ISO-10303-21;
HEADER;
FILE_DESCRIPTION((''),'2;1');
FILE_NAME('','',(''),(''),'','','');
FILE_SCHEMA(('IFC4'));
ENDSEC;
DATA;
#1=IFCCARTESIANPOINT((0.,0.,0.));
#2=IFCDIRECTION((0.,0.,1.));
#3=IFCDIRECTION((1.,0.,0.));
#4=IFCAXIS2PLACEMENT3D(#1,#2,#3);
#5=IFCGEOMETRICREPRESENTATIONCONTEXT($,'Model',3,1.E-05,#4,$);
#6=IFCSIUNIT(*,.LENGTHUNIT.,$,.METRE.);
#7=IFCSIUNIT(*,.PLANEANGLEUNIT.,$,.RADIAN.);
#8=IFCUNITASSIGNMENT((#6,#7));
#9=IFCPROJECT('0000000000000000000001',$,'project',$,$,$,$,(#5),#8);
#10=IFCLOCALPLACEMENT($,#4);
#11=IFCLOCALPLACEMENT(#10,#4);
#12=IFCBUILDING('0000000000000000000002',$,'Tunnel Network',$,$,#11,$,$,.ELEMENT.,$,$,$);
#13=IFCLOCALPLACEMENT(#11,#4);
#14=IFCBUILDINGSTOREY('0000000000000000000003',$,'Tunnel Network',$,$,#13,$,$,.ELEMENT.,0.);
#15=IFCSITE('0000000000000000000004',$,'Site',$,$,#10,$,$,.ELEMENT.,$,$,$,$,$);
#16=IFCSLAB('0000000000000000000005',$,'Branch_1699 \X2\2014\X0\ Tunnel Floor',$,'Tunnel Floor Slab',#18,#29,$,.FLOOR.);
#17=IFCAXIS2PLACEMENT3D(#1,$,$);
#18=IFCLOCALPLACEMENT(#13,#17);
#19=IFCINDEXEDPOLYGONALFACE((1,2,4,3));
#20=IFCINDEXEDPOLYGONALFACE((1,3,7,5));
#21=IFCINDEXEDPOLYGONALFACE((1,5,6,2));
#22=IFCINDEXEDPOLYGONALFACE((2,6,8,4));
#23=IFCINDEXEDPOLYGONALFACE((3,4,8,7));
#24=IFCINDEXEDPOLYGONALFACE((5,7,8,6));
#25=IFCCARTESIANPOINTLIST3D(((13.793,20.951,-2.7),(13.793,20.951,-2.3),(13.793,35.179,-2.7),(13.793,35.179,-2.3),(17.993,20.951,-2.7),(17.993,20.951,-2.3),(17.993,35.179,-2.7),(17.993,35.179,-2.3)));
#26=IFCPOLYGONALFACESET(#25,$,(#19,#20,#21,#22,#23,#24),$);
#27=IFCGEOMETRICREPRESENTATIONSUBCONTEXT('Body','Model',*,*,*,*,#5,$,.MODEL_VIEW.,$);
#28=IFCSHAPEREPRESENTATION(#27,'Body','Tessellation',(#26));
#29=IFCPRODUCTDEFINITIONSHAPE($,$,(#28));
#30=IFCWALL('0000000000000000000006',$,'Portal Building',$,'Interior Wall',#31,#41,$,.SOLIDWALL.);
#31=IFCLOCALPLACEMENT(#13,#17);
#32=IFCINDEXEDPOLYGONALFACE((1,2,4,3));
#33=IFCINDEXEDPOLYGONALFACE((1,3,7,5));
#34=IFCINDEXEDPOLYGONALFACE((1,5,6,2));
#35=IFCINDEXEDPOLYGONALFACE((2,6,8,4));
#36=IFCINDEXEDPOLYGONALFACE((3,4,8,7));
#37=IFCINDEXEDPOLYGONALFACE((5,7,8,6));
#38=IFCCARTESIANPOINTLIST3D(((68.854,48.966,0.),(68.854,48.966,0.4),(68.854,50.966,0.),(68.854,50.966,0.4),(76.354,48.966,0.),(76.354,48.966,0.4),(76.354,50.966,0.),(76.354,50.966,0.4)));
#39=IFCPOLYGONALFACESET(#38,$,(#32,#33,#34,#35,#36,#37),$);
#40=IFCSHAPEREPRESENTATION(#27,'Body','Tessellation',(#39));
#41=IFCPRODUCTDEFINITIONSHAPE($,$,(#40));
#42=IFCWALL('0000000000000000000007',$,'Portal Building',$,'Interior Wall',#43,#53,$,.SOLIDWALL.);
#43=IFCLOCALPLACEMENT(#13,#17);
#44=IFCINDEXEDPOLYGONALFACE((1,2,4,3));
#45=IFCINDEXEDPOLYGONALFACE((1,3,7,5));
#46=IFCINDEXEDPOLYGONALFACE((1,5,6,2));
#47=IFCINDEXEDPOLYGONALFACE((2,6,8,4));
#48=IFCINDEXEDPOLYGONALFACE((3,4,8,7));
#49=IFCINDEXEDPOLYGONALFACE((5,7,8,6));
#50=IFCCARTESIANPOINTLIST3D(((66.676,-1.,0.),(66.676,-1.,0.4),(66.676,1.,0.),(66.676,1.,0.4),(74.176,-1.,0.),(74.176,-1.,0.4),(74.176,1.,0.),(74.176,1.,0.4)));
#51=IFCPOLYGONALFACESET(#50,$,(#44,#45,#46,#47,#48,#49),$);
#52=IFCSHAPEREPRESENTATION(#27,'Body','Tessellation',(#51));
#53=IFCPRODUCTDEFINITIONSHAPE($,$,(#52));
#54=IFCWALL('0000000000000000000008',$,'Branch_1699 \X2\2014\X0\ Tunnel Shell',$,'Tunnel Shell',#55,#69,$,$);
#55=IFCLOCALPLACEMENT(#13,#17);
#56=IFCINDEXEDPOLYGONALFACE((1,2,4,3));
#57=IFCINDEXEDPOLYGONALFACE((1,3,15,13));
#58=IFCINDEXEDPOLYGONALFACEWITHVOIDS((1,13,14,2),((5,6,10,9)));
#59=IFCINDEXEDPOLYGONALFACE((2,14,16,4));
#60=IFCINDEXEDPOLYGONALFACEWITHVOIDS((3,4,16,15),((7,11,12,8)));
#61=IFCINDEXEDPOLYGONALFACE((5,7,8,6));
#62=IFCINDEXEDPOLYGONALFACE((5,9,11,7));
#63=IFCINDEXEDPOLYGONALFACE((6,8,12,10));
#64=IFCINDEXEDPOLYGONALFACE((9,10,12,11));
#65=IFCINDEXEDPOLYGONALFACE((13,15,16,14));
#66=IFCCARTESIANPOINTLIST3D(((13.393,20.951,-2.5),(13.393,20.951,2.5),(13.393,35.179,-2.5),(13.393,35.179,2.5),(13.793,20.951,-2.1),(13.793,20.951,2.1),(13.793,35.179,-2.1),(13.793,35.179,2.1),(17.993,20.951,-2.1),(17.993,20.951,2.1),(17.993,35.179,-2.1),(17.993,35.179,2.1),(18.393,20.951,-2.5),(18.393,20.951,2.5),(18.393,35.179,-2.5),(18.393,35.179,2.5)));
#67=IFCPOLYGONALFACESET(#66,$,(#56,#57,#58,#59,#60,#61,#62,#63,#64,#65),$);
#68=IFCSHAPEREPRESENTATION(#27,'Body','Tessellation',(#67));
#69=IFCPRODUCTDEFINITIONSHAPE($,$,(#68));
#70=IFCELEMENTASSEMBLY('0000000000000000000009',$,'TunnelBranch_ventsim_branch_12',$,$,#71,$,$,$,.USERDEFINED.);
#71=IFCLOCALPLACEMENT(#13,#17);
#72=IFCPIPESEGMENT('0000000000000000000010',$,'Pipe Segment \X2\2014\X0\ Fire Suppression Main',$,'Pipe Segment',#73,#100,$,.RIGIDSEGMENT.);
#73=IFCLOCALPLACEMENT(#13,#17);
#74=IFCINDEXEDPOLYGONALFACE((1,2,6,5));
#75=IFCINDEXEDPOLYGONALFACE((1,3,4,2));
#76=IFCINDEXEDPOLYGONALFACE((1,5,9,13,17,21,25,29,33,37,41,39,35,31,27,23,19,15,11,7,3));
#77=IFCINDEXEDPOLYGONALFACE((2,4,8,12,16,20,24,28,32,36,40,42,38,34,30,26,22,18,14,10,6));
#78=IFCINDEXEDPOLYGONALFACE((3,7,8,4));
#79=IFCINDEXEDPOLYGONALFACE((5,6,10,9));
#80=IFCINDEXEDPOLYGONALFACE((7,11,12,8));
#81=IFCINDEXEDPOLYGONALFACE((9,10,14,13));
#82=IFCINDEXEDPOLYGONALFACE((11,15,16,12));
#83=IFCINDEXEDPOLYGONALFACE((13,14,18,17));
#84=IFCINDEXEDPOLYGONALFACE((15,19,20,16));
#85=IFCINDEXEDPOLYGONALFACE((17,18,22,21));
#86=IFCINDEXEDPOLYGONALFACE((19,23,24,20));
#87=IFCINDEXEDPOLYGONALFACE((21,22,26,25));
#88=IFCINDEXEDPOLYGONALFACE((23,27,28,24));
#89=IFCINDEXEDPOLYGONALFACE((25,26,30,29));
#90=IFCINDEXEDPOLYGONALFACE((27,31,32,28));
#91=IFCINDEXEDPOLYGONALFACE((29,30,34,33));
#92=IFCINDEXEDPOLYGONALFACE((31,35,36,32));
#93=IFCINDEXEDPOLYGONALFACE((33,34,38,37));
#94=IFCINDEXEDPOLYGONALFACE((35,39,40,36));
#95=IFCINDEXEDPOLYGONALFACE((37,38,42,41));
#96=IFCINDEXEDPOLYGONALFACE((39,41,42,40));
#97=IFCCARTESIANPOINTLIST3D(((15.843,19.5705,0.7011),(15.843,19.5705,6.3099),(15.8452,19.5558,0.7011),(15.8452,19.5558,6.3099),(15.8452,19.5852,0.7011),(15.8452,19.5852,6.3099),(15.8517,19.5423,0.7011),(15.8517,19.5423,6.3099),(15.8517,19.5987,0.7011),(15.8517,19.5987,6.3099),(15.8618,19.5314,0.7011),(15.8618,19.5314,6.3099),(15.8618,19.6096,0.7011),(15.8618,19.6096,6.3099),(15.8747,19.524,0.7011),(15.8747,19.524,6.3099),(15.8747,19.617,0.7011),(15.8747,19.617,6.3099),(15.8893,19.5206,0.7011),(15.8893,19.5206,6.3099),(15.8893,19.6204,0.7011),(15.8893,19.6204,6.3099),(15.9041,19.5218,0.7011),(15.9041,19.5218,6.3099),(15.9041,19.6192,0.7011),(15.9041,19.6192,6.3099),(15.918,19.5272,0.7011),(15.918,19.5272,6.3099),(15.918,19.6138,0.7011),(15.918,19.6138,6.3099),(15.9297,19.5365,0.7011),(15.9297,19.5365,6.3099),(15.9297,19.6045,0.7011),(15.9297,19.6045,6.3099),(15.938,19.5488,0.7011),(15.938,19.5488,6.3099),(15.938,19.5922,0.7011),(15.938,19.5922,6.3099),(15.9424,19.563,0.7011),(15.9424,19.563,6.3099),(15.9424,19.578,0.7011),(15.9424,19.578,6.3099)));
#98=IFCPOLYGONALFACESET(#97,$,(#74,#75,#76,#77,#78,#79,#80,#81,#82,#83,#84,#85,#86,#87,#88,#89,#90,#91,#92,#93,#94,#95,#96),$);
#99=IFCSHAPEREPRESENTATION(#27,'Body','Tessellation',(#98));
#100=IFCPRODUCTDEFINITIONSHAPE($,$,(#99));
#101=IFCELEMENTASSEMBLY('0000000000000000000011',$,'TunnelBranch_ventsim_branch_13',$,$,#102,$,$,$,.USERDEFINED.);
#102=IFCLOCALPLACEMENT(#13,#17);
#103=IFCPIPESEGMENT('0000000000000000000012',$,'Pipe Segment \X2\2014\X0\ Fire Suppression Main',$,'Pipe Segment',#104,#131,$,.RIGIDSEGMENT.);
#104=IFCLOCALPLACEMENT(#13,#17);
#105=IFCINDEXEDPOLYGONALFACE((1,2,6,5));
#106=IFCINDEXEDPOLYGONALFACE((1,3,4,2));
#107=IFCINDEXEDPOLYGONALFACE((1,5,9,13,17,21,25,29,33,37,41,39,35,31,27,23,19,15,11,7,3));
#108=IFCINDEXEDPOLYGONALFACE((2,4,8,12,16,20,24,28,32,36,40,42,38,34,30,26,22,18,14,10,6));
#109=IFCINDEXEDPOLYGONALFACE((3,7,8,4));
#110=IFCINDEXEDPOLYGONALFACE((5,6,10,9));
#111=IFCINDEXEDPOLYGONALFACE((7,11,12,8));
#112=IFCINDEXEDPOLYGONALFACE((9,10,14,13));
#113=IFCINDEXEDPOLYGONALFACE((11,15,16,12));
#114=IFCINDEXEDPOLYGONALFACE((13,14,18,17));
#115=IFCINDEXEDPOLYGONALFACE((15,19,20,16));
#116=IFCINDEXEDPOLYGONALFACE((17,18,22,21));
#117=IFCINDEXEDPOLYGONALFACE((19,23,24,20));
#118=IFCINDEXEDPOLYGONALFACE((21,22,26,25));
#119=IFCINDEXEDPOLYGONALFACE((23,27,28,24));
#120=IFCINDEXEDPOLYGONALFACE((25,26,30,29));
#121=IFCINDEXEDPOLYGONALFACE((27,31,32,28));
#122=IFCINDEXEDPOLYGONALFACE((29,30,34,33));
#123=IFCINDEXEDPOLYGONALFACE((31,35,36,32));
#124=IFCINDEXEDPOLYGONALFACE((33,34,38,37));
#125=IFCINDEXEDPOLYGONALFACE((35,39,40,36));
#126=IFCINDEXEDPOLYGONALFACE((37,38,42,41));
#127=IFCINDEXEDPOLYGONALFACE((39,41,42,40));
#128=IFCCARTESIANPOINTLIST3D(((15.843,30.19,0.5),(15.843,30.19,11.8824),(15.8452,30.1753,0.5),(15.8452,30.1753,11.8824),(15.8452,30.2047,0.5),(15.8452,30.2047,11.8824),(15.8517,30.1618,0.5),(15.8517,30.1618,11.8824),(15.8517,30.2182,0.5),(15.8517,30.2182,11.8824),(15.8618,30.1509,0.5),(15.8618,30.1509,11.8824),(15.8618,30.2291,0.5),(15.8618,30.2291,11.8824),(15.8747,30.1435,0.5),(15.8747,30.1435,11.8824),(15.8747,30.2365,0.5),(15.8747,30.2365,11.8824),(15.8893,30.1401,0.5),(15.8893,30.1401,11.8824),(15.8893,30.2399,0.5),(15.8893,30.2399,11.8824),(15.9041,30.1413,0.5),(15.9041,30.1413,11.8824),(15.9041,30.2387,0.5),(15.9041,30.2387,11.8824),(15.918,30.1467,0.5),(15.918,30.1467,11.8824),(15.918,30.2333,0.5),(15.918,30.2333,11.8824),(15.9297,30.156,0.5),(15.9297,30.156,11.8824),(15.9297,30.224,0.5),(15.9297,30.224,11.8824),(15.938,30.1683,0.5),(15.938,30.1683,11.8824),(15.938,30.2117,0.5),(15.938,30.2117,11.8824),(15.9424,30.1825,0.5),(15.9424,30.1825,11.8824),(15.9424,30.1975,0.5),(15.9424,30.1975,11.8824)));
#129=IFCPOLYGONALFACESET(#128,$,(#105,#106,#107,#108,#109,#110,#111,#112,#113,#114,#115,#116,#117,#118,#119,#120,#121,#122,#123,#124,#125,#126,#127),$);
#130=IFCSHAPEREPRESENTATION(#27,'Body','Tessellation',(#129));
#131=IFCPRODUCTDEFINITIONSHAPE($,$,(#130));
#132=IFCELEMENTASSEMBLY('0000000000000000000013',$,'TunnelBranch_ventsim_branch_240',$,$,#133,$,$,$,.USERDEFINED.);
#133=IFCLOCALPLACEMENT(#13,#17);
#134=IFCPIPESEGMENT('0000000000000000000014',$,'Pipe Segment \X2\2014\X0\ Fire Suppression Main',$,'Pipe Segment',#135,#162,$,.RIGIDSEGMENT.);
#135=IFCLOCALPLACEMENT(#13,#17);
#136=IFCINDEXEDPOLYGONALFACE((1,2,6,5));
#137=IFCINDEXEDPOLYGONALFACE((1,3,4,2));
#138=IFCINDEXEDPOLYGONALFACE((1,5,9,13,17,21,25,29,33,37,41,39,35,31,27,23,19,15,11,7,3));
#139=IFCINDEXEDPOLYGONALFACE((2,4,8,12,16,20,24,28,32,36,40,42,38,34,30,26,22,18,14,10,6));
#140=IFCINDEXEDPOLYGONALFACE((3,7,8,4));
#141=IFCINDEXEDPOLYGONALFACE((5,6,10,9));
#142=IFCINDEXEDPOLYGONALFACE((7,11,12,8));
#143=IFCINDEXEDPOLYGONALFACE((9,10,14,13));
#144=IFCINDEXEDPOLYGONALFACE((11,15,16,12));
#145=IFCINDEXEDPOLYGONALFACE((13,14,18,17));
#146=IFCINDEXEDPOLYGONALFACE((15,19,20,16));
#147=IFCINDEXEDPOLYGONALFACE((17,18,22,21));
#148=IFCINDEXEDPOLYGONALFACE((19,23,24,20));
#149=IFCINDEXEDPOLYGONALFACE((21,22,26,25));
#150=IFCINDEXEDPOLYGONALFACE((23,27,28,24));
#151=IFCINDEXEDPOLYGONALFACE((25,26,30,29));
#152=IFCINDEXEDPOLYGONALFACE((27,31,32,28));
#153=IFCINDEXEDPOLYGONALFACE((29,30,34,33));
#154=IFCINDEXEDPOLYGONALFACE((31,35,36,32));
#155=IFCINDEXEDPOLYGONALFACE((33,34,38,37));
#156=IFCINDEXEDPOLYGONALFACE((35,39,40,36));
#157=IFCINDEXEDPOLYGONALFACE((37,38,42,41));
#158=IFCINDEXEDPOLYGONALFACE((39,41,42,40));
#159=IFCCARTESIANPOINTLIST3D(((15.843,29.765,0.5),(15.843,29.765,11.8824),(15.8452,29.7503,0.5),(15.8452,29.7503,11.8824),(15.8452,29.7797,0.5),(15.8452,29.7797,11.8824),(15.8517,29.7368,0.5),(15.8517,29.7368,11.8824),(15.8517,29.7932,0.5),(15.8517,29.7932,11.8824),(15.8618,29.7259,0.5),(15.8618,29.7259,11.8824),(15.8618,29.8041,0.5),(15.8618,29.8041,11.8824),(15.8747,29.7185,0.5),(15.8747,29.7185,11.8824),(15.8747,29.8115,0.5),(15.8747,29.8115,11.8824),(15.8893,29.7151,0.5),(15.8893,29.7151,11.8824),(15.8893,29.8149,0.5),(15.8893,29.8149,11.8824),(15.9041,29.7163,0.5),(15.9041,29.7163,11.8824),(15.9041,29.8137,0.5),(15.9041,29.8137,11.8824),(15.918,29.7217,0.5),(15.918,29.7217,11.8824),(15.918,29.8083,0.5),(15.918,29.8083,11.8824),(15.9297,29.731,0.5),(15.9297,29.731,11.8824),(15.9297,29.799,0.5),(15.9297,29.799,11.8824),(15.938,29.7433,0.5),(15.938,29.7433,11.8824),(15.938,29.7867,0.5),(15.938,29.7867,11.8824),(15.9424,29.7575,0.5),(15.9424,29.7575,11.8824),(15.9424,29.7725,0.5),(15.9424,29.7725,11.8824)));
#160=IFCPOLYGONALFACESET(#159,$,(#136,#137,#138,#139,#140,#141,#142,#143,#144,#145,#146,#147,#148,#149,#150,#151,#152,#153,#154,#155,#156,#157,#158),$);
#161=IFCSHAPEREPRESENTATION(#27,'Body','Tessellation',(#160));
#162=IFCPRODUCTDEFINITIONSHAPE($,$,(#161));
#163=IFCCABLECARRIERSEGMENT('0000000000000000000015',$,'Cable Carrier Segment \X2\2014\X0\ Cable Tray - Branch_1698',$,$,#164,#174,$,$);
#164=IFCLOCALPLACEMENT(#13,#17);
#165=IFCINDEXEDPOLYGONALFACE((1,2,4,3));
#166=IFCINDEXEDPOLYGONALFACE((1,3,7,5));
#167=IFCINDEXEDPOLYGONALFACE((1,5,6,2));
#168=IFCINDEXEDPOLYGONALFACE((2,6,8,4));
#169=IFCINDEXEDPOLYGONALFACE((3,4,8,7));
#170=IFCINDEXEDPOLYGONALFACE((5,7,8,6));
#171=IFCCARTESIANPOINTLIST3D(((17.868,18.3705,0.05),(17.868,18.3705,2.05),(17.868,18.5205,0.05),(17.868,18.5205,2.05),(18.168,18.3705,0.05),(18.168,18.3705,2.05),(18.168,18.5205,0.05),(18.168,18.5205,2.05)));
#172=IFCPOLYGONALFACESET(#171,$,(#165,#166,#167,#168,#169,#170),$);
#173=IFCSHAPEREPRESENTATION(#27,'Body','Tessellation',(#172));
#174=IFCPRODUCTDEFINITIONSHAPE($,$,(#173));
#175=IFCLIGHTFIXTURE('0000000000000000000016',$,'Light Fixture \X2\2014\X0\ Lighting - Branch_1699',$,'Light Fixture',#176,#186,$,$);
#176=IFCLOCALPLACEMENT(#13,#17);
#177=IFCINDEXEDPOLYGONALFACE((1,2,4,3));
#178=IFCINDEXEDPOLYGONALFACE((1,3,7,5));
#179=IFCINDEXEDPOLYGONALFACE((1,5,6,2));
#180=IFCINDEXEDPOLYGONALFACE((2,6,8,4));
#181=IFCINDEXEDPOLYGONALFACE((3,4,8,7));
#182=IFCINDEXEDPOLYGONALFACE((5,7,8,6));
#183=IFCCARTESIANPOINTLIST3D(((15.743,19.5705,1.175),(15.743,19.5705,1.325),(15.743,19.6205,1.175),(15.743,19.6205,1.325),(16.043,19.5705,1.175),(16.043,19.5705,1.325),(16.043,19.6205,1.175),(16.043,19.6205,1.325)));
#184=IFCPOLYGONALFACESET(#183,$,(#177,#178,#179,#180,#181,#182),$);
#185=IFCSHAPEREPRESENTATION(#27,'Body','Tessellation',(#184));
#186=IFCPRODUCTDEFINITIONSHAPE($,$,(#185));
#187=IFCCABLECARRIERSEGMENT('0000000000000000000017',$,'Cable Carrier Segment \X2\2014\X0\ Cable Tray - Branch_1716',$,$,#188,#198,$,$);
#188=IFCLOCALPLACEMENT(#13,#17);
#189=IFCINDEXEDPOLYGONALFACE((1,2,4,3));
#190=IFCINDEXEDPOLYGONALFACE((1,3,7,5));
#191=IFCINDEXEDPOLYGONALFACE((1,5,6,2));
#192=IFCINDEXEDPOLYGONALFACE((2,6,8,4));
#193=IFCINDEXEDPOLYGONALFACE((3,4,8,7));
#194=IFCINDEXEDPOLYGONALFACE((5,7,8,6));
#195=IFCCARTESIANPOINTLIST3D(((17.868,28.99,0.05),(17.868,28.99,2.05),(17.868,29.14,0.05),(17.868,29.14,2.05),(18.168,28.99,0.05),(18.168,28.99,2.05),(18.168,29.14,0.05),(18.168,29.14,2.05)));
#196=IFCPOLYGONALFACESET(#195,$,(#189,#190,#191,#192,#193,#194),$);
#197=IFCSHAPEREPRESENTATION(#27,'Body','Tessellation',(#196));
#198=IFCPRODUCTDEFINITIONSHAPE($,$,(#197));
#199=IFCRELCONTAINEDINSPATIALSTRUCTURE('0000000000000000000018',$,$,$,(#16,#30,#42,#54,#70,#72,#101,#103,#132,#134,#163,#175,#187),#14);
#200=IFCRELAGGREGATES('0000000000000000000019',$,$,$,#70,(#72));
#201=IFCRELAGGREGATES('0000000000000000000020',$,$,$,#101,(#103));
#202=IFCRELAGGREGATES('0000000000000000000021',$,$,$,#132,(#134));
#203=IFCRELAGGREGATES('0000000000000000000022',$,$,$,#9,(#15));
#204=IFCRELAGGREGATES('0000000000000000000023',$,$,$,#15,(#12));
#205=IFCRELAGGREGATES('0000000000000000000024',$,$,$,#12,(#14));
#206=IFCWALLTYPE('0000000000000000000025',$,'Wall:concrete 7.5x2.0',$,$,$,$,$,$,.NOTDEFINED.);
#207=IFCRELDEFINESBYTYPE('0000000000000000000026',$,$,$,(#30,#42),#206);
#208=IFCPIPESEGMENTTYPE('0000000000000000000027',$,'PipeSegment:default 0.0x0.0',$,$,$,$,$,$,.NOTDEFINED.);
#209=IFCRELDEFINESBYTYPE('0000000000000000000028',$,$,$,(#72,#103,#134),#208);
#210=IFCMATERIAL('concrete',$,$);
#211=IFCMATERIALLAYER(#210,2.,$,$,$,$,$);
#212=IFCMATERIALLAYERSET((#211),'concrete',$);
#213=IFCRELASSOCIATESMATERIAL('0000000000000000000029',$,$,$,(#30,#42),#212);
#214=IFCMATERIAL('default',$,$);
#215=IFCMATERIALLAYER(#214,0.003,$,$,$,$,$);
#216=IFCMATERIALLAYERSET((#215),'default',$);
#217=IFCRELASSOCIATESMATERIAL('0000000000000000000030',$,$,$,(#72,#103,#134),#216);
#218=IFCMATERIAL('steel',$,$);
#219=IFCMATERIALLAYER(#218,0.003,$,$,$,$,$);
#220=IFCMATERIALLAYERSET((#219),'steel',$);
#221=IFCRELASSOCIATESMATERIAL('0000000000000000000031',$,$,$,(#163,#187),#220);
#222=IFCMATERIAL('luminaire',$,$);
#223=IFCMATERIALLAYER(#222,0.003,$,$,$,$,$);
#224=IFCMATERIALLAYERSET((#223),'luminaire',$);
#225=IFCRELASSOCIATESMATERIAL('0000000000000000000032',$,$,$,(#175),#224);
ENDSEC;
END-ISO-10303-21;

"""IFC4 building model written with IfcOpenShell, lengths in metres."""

from ifc_helpers import new_model, si_unit, frame, origin_with_axes, origin_2d_with_axis, place, context, subcontext, project, spatial, rectangle, hollow_rectangle, circle, extrude, material, layer, layer_set, layer_usage, type_object, element, aggregate, save


model = new_model("IFC4")

# Units and contexts
model_context = context("Model", 3, precision=1e-05, world=origin_with_axes())
body_context = subcontext(model_context, "Body", "Model", "MODEL_VIEW")
ifc_project = project(units=[si_unit("LENGTHUNIT", "METRE"), si_unit("PLANEANGLEUNIT", "RADIAN")], contexts=[model_context])

# Site, building, storey
site_placement = place(None, origin_with_axes())
site = spatial("IfcSite", under=ifc_project, at=site_placement, Name="Site", CompositionType="ELEMENT")
building_placement = place(site_placement, origin_with_axes())
building = spatial("IfcBuilding", under=site, at=building_placement, Name="Tunnel Network", CompositionType="ELEMENT")
storey_placement = place(building_placement, origin_with_axes())
storey = spatial("IfcBuildingStorey", under=building, at=storey_placement, Name="Tunnel Network", CompositionType="ELEMENT", Elevation=0.0)

# Slab
placement = place(storey_placement, frame((15.893, 20.951, 0.0), z_axis=(0.0, 0.0, 1.0), x_axis=(0.0, 1.0, 0.0)))
element("IfcSlab", 1, at=placement, inside=storey, Name="Branch_1699 — Tunnel Floor", ObjectType="Tunnel Floor Slab", PredefinedType="FLOOR", context=body_context, shape_type="SweptSolid", body=[
    extrude(rectangle(XDim=0.4, YDim=4.2, at=origin_2d_with_axis()), frame((0.0, 0.0, -2.5), z_axis=(1.0, 0.0, 0.0), x_axis=(0.0, 0.0, 1.0)), (0.0, 0.0, 1.0), 14.228),
])

# Walls
ifc_material_1 = material(Name="concrete")
ifc_layer_1 = layer(ifc_material_1, 2.0)
ifc_layer_set_1 = layer_set([ifc_layer_1], Name="concrete")
ifc_layer_usage_1 = layer_usage(ifc_layer_set_1, "AXIS2", "POSITIVE", 0.0)
wall_type = type_object("IfcWallType", Name="Wall:concrete 7.5x2.0")
wall_1_placement = place(storey_placement, frame((72.604, 49.966, 0.0), z_axis=(0.0, 0.0, 1.0), x_axis=(1.0, 0.0, 0.0)))
element("IfcWall", 2, at=wall_1_placement, inside=storey, type_object=wall_type, material=ifc_layer_usage_1, Name="Portal Building", ObjectType="Interior Wall", PredefinedType="SOLIDWALL", context=body_context, shape_type="SweptSolid", body=[
    extrude(rectangle(XDim=7.5, YDim=2.0, at=origin_2d_with_axis()), origin_with_axes(), (0.0, 0.0, 1.0), 0.4),
])
ifc_layer_usage_2 = layer_usage(ifc_layer_set_1, "AXIS2", "POSITIVE", 0.0)
wall_2_placement = place(storey_placement, frame((70.426, 0.0, 0.0), z_axis=(0.0, 0.0, 1.0), x_axis=(1.0, 0.0, 0.0)))
element("IfcWall", 3, at=wall_2_placement, inside=storey, type_object=wall_type, material=ifc_layer_usage_2, Name="Portal Building", ObjectType="Interior Wall", PredefinedType="SOLIDWALL", context=body_context, shape_type="SweptSolid", body=[
    extrude(rectangle(XDim=7.5, YDim=2.0, at=origin_2d_with_axis()), origin_with_axes(), (0.0, 0.0, 1.0), 0.4),
])
element("IfcWall", 4, at=placement, inside=storey, Name="Branch_1699 — Tunnel Shell", ObjectType="Tunnel Shell", context=body_context, shape_type="SweptSolid", body=[
    extrude(hollow_rectangle(XDim=5.0, YDim=5.0, WallThickness=0.4, at=origin_2d_with_axis()), frame((0.0, 0.0, 0.0), z_axis=(1.0, 0.0, 0.0), x_axis=(0.0, 0.0, 1.0)), (0.0, 0.0, 1.0), 14.228),
])

# Element assemblies, pipe segments
assembly_1_placement = place(storey_placement, frame((15.893, 19.5705, 0.7011), z_axis=(0.0, 0.0, 1.0), x_axis=(-1.0, 0.0, 0.0)))
assembly_1 = element("IfcElementAssembly", 5, at=assembly_1_placement, inside=storey, Name="TunnelBranch_ventsim_branch_12", PredefinedType="USERDEFINED")
ifc_material_2 = material(Name="default")
ifc_layer_2 = layer(ifc_material_2, 0.003)
ifc_layer_set_2 = layer_set([ifc_layer_2], Name="default")
ifc_layer_usage_3 = layer_usage(ifc_layer_set_2, "AXIS2", "POSITIVE", 0.0)
pipe_segment_type = type_object("IfcPipeSegmentType", Name="PipeSegment:default 0.0x0.0")
pipe_segment_1_placement = place(storey_placement, frame((15.893, 19.5705, 0.7011), z_axis=(0.0, 0.0, 1.0), x_axis=(-1.0, 0.0, 0.0)))
pipe_segment_1 = element("IfcPipeSegment", 6, at=pipe_segment_1_placement, inside=storey, type_object=pipe_segment_type, material=ifc_layer_usage_3, Name="Pipe Segment — Fire Suppression Main", ObjectType="Pipe Segment", PredefinedType="RIGIDSEGMENT", context=body_context, shape_type="SweptSolid", body=[
    extrude(circle(Radius=0.05, at=origin_2d_with_axis()), origin_with_axes(), (0.0, 0.0, 1.0), 5.6088),
])
assembly_2_placement = place(storey_placement, frame((15.893, 30.19, 1.25), z_axis=(0.0, 1.0, 0.0), x_axis=(-1.0, 0.0, 0.0)))
assembly_2 = element("IfcElementAssembly", 7, at=assembly_2_placement, inside=storey, Name="TunnelBranch_ventsim_branch_13", PredefinedType="USERDEFINED")
ifc_layer_usage_4 = layer_usage(ifc_layer_set_2, "AXIS2", "POSITIVE", 0.0)
pipe_segment_2_placement = place(storey_placement, frame((15.893, 30.19, 0.5), z_axis=(0.0, 0.0, 1.0), x_axis=(-1.0, 0.0, 0.0)))
pipe_segment_2 = element("IfcPipeSegment", 8, at=pipe_segment_2_placement, inside=storey, type_object=pipe_segment_type, material=ifc_layer_usage_4, Name="Pipe Segment — Fire Suppression Main", ObjectType="Pipe Segment", PredefinedType="RIGIDSEGMENT", context=body_context, shape_type="SweptSolid", body=[
    extrude(circle(Radius=0.05, at=origin_2d_with_axis()), origin_with_axes(), (0.0, 0.0, 1.0), 11.3824),
])
assembly_3_placement = place(storey_placement, frame((15.893, 29.765, 1.25), z_axis=(0.0, 1.0, 0.0), x_axis=(-1.0, 0.0, 0.0)))
assembly_3 = element("IfcElementAssembly", 9, at=assembly_3_placement, inside=storey, Name="TunnelBranch_ventsim_branch_240", PredefinedType="USERDEFINED")
ifc_layer_usage_5 = layer_usage(ifc_layer_set_2, "AXIS2", "POSITIVE", 0.0)
pipe_segment_3_placement = place(storey_placement, frame((15.893, 29.765, 0.5), z_axis=(0.0, 0.0, 1.0), x_axis=(-1.0, 0.0, 0.0)))
pipe_segment_3 = element("IfcPipeSegment", 10, at=pipe_segment_3_placement, inside=storey, type_object=pipe_segment_type, material=ifc_layer_usage_5, Name="Pipe Segment — Fire Suppression Main", ObjectType="Pipe Segment", PredefinedType="RIGIDSEGMENT", context=body_context, shape_type="SweptSolid", body=[
    extrude(circle(Radius=0.05, at=origin_2d_with_axis()), origin_with_axes(), (0.0, 0.0, 1.0), 11.3824),
])

# Cable carrier segment
ifc_material_3 = material(Name="steel")
ifc_layer_3 = layer(ifc_material_3, 0.003)
ifc_layer_set_3 = layer_set([ifc_layer_3], Name="steel")
ifc_layer_usage_6 = layer_usage(ifc_layer_set_3, "AXIS2", "POSITIVE", 0.0)
cable_carrier_segment_1_placement = place(storey_placement, frame((18.018, 18.4455, 0.05), z_axis=(0.0, 0.0, 1.0), x_axis=(-1.0, 0.0, 0.0)))
element("IfcCableCarrierSegment", 11, at=cable_carrier_segment_1_placement, inside=storey, material=ifc_layer_usage_6, Name="Cable Carrier Segment — Cable Tray - Branch_1698", context=body_context, shape_type="SweptSolid", body=[
    extrude(rectangle(XDim=0.3, YDim=0.15, at=origin_2d_with_axis()), origin_with_axes(), (0.0, 0.0, 1.0), 2.0),
])

# Light fixture
ifc_material_4 = material(Name="luminaire")
ifc_layer_4 = layer(ifc_material_4, 0.003)
ifc_layer_set_4 = layer_set([ifc_layer_4], Name="luminaire")
ifc_layer_usage_7 = layer_usage(ifc_layer_set_4, "AXIS2", "POSITIVE", 0.0)
light_fixture_1_placement = place(storey_placement, frame((15.893, 19.5705, 1.25), z_axis=(0.0, 1.0, 0.0), x_axis=(-1.0, 0.0, 0.0)))
element("IfcLightFixture", 12, at=light_fixture_1_placement, inside=storey, material=ifc_layer_usage_7, Name="Light Fixture — Lighting - Branch_1699", ObjectType="Light Fixture", context=body_context, shape_type="SweptSolid", body=[
    extrude(rectangle(XDim=0.3, YDim=0.15, at=origin_2d_with_axis()), origin_with_axes(), (0.0, 0.0, 1.0), 0.05),
])

# Cable carrier segment
ifc_layer_usage_8 = layer_usage(ifc_layer_set_3, "AXIS2", "POSITIVE", 0.0)
cable_carrier_segment_2_placement = place(storey_placement, frame((18.018, 29.065, 0.05), z_axis=(0.0, 0.0, 1.0), x_axis=(-1.0, 0.0, 0.0)))
element("IfcCableCarrierSegment", 13, at=cable_carrier_segment_2_placement, inside=storey, material=ifc_layer_usage_8, Name="Cable Carrier Segment — Cable Tray - Branch_1716", context=body_context, shape_type="SweptSolid", body=[
    extrude(rectangle(XDim=0.3, YDim=0.15, at=origin_2d_with_axis()), origin_with_axes(), (0.0, 0.0, 1.0), 2.0),
])

aggregate(assembly_1, [pipe_segment_1])

aggregate(assembly_2, [pipe_segment_2])

aggregate(assembly_3, [pipe_segment_3])

save(model, "model.ifc")
